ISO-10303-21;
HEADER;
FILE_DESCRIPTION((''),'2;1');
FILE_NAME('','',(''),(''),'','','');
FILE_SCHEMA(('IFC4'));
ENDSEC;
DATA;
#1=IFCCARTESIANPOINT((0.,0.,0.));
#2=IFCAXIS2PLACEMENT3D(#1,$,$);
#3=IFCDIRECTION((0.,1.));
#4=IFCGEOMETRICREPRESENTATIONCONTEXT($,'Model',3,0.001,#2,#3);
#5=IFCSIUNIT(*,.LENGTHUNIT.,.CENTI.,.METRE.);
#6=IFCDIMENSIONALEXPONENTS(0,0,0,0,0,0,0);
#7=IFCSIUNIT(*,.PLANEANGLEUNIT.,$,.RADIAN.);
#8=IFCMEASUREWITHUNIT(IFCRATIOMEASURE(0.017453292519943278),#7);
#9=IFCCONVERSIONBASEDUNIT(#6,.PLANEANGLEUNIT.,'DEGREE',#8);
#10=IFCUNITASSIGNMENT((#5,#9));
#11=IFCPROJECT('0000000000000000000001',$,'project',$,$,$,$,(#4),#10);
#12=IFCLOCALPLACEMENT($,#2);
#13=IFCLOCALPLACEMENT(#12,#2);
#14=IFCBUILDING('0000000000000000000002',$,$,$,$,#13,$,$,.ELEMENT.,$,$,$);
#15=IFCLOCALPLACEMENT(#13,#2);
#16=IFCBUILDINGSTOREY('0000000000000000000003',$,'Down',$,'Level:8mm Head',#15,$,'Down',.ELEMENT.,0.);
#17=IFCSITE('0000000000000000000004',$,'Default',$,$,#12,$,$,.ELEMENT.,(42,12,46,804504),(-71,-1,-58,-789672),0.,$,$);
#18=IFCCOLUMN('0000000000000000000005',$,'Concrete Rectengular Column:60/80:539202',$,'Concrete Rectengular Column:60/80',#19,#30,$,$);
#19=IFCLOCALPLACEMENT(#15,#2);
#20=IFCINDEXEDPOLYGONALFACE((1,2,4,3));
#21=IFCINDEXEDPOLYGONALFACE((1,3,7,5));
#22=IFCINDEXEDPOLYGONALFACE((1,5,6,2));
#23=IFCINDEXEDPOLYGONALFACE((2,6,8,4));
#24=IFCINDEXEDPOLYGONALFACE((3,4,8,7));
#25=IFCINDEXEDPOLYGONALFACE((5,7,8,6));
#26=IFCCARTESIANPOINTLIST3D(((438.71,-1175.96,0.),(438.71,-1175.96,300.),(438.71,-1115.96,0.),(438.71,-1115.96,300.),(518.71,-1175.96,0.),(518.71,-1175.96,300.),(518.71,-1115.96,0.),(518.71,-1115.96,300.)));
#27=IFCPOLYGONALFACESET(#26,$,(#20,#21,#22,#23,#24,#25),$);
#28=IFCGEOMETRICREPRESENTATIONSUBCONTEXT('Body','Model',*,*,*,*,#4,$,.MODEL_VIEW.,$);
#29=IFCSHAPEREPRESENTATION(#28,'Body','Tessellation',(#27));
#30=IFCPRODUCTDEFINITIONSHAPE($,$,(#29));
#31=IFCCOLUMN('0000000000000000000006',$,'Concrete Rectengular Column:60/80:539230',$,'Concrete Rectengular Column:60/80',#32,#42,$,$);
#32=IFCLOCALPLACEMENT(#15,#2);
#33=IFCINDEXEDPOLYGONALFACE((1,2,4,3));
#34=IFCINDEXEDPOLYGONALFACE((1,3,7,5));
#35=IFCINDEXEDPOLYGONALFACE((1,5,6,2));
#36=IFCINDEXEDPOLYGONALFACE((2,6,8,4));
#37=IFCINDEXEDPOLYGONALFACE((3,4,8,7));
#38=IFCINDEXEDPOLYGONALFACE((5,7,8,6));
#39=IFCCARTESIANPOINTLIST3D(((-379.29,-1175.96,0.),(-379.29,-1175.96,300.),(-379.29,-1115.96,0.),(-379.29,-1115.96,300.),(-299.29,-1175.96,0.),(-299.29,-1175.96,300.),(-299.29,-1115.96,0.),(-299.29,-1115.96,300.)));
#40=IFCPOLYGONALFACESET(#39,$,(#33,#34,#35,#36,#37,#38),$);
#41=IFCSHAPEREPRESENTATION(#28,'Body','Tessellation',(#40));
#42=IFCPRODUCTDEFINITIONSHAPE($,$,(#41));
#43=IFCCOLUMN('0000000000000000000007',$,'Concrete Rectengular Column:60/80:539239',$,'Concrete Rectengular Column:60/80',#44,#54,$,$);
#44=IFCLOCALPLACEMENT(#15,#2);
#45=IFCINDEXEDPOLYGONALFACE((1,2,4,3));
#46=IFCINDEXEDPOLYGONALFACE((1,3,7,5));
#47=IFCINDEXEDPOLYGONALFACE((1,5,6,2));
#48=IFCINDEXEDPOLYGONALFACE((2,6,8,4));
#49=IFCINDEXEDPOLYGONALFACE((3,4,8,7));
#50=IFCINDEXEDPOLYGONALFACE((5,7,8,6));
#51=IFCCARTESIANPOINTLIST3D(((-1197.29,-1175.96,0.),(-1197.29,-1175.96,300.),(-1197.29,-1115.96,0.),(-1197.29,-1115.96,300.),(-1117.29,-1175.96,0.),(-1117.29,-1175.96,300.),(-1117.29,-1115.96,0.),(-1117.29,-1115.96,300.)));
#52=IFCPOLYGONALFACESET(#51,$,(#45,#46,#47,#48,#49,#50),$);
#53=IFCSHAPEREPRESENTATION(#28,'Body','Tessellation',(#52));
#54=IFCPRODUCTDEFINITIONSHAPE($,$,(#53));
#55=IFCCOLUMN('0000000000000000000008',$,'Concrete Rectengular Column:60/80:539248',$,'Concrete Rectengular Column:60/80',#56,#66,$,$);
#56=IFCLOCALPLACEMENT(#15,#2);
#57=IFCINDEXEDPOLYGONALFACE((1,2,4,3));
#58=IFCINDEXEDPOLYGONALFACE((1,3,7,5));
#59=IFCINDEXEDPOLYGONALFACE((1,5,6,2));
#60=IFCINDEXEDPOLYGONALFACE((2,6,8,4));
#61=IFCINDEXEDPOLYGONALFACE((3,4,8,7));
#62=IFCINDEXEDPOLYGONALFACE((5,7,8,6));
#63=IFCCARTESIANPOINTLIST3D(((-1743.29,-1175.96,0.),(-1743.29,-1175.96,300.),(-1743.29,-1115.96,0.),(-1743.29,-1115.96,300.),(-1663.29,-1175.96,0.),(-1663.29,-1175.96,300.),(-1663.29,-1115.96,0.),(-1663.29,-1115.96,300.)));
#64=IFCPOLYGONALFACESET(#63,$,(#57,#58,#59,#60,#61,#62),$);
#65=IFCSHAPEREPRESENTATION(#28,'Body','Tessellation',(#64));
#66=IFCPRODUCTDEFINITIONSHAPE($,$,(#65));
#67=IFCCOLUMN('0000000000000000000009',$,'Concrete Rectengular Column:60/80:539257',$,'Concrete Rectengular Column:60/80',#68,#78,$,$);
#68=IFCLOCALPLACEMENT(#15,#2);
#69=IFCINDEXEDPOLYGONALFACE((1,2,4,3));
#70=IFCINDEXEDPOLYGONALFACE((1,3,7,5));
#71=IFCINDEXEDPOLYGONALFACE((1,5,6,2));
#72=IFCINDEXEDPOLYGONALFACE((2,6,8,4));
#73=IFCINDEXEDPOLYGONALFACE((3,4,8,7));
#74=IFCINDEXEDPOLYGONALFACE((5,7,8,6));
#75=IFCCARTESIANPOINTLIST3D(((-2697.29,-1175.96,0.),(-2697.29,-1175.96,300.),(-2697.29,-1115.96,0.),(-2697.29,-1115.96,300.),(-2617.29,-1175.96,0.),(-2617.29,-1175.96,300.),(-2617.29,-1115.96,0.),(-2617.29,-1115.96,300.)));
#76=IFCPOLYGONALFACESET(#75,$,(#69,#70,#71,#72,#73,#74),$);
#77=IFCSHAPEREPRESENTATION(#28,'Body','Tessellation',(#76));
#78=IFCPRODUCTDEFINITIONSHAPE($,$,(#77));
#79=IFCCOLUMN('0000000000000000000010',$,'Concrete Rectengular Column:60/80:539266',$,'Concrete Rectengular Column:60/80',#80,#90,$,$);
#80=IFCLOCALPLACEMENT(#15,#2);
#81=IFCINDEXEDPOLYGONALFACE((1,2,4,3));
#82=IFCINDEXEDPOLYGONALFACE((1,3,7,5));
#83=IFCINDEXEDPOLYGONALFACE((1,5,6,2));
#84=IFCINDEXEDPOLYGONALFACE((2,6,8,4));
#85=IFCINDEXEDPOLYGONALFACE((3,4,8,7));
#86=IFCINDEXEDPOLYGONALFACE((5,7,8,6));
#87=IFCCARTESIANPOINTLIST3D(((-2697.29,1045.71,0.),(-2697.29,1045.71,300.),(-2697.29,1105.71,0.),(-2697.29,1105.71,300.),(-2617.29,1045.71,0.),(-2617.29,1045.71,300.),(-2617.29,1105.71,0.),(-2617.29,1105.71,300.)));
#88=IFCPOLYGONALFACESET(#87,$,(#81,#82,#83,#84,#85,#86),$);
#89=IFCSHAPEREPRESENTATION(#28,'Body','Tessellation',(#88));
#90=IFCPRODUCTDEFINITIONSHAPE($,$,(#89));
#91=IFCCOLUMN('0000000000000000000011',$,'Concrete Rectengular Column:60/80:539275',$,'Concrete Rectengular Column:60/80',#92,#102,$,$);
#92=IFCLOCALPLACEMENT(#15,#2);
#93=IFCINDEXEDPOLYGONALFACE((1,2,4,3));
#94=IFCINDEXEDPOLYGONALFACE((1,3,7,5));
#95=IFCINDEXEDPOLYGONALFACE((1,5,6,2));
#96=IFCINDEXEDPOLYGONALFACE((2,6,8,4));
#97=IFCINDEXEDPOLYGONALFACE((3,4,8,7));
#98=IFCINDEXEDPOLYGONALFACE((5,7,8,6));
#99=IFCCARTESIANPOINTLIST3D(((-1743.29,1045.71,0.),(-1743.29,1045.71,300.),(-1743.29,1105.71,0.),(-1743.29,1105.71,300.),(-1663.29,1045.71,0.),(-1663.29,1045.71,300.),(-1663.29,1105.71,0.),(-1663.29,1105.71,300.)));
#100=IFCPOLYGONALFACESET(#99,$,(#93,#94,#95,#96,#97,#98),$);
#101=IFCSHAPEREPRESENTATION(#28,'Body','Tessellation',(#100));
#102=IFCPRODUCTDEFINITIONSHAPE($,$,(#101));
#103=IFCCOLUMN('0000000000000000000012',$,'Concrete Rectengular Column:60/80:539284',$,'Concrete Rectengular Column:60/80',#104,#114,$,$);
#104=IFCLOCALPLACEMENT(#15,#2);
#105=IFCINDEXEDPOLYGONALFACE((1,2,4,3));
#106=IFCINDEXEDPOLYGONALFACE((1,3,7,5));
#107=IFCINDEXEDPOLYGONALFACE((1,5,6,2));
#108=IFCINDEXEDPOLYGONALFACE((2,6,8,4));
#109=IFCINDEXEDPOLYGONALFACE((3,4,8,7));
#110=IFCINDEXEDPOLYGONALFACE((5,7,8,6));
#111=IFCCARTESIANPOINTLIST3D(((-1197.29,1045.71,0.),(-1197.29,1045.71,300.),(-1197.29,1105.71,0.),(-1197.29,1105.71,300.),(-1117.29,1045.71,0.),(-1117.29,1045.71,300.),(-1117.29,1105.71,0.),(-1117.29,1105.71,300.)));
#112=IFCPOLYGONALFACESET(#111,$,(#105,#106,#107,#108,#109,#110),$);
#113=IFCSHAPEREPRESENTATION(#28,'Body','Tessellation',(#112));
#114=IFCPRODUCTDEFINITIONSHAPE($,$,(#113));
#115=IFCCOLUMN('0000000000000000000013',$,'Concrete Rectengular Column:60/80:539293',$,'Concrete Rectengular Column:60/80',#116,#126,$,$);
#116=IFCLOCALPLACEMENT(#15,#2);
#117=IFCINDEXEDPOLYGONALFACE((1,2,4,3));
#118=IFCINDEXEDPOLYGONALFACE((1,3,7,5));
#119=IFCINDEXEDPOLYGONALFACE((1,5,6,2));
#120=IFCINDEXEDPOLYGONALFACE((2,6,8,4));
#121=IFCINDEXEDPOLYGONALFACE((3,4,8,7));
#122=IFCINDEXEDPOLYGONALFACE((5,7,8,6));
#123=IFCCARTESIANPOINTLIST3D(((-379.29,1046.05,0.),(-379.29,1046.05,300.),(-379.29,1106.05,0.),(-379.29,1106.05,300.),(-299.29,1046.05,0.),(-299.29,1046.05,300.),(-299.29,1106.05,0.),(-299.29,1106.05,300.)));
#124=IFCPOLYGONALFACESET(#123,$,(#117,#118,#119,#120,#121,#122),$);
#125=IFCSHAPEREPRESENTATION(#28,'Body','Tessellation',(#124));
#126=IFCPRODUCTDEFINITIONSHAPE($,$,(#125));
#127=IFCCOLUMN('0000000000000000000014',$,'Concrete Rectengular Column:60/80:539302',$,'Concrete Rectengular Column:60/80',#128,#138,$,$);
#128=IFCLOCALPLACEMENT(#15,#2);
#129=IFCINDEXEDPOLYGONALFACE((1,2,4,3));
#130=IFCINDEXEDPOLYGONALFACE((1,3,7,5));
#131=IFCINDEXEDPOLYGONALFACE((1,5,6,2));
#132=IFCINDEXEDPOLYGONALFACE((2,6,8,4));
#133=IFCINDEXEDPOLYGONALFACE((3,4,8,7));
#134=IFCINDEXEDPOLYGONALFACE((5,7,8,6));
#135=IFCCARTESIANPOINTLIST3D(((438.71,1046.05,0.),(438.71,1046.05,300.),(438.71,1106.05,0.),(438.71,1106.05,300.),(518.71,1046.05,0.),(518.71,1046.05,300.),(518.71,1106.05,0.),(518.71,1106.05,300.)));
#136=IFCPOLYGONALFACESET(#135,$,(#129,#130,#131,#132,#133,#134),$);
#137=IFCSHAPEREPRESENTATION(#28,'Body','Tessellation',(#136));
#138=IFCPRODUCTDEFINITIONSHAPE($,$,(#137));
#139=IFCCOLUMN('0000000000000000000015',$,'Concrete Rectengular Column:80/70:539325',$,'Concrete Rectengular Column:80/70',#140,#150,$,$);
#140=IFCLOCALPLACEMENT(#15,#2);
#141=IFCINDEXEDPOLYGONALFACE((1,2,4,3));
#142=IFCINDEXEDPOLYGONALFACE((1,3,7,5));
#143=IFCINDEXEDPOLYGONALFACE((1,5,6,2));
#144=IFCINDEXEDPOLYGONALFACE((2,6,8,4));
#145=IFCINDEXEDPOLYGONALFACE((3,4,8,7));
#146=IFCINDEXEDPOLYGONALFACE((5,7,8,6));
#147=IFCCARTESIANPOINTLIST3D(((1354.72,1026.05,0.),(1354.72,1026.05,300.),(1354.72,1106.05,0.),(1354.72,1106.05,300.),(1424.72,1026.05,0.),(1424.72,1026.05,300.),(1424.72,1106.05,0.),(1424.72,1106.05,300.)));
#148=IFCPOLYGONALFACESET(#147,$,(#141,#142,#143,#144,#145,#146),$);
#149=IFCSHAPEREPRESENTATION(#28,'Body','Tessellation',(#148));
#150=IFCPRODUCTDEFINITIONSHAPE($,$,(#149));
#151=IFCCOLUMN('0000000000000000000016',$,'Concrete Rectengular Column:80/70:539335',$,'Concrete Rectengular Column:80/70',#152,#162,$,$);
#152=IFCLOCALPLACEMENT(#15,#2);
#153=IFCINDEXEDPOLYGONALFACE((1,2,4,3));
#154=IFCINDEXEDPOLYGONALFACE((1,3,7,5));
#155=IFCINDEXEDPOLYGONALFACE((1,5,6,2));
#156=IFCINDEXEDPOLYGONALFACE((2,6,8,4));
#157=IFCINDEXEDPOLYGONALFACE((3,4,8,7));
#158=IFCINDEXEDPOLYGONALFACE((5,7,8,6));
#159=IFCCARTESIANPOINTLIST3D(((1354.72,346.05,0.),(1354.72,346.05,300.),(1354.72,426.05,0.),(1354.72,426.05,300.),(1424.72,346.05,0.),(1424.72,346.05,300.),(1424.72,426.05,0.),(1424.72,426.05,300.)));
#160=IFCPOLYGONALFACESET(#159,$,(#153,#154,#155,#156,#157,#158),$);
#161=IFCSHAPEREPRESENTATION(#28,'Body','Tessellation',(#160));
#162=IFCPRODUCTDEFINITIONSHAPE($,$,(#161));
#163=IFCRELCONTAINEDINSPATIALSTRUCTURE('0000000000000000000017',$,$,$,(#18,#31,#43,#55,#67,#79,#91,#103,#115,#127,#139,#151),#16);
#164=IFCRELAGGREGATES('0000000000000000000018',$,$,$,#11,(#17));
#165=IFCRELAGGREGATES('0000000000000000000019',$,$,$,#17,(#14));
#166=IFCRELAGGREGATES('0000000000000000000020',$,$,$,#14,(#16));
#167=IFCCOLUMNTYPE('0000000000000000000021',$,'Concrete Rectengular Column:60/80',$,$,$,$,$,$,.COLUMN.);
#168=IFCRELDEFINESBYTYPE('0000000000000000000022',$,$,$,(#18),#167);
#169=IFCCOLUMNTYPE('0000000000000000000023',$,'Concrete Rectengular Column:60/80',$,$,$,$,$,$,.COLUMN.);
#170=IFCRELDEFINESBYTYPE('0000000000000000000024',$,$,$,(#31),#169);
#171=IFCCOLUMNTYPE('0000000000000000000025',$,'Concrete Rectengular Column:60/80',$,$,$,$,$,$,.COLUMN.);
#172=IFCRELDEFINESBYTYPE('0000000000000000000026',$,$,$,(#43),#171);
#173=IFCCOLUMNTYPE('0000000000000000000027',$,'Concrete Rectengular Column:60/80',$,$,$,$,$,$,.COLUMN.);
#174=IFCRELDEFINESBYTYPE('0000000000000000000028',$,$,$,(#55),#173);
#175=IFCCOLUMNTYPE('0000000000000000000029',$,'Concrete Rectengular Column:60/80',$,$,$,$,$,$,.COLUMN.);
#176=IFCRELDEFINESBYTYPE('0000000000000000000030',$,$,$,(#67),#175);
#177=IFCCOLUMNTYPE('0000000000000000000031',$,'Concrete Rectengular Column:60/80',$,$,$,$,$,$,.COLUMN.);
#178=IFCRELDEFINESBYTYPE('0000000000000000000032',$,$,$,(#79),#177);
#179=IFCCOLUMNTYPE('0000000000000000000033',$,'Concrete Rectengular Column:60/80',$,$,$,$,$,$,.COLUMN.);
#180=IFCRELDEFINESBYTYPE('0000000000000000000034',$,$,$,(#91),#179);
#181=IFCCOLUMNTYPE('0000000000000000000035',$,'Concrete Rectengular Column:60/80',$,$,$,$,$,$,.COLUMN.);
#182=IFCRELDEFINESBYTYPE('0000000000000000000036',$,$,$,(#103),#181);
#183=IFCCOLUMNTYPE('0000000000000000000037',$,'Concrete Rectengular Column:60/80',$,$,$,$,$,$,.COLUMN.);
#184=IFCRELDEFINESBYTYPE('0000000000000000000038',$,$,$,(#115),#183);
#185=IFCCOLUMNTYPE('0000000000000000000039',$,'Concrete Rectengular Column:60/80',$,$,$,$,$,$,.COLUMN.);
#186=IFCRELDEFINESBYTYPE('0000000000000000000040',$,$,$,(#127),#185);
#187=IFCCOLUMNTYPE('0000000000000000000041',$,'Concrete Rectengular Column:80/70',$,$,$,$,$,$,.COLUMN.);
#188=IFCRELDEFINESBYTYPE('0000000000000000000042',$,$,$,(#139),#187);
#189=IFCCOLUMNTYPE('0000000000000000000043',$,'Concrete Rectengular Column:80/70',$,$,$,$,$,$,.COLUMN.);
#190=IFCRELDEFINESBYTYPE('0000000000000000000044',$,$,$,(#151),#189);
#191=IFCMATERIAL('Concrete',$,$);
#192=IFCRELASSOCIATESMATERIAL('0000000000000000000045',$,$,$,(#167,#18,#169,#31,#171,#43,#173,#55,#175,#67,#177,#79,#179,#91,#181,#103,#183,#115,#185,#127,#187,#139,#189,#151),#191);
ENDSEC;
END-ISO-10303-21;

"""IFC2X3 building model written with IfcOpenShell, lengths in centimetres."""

from ifc_helpers import new_model, entity, si_unit, converted_unit, direction, frame, frame_2d, origin, origin_2d_with_axis, place, context, subcontext, project, spatial, rectangle, extrude, source, transform, mapped, material, type_object, type_shapes, element, save


model = new_model("IFC2X3")

# Units and contexts
model_context = context("Model", 3, precision=0.001, world=origin(), true_north=direction((0.0, 1.0)))
body_context = subcontext(model_context, "Body", "Model", "MODEL_VIEW")
ifc_project = project(units=[si_unit("LENGTHUNIT", "METRE", prefix="CENTI"), converted_unit("PLANEANGLEUNIT", "DEGREE", entity("IfcRatioMeasure", 0.017453292519943278), si_unit("PLANEANGLEUNIT", "RADIAN"), dimensions=[0, 0, 0, 0, 0, 0, 0])], contexts=[model_context])

# Site, building, storey
site_placement = place(None, origin())
site = spatial("IfcSite", under=ifc_project, at=site_placement, Name="Default", CompositionType="ELEMENT", RefLatitude=(42, 12, 46, 804504), RefLongitude=(-71, -1, -58, -789672), RefElevation=0.0)
building_placement = place(site_placement, origin())
building = spatial("IfcBuilding", under=site, at=building_placement, CompositionType="ELEMENT")
storey_placement = place(building_placement, origin())
storey = spatial("IfcBuildingStorey", under=building, at=storey_placement, Name="Down", ObjectType="Level:8mm Head", LongName="Down", CompositionType="ELEMENT", Elevation=0.0)

# Columns
ifc_material = material(Name="Concrete")
column_type_1 = type_object("IfcColumnType", Name="Concrete Rectengular Column:60/80", PredefinedType="COLUMN", material=ifc_material)
shared_shape_1 = source(origin(), body_context, "Body", "SweptSolid", [
    extrude(rectangle(XDim=60.0, YDim=80.0, at=frame_2d((0.0, 0.0), x_axis=(1.0, 0.0))), frame((478.71, -1145.96, 0.0), z_axis=(0.0, 0.0, 1.0), x_axis=(0.0, -1.0, 0.0)), (0.0, 0.0, 1.0), 300.0),
])
type_shapes(column_type_1, [shared_shape_1])
column_1_placement = place(storey_placement, origin())
element("IfcColumn", 1, at=column_1_placement, inside=storey, type_object=column_type_1, material=ifc_material, Name="Concrete Rectengular Column:60/80:539202", ObjectType="Concrete Rectengular Column:60/80", context=body_context, shape_type="MappedRepresentation", body=[
    mapped(shared_shape_1, transform((0.0, 0.0, 0.0), scale=1.0)),
])
column_type_2 = type_object("IfcColumnType", Name="Concrete Rectengular Column:60/80", PredefinedType="COLUMN", material=ifc_material)
shared_shape_2 = source(origin(), body_context, "Body", "SweptSolid", [
    extrude(rectangle(XDim=60.0, YDim=80.0, at=frame_2d((0.0, 0.0), x_axis=(1.0, 0.0))), frame((-339.29, -1145.96, 0.0), z_axis=(0.0, 0.0, 1.0), x_axis=(0.0, -1.0, 0.0)), (0.0, 0.0, 1.0), 300.0),
])
type_shapes(column_type_2, [shared_shape_2])
column_2_placement = place(storey_placement, origin())
element("IfcColumn", 2, at=column_2_placement, inside=storey, type_object=column_type_2, material=ifc_material, Name="Concrete Rectengular Column:60/80:539230", ObjectType="Concrete Rectengular Column:60/80", context=body_context, shape_type="MappedRepresentation", body=[
    mapped(shared_shape_2, transform((0.0, 0.0, 0.0), scale=1.0)),
])
column_type_3 = type_object("IfcColumnType", Name="Concrete Rectengular Column:60/80", PredefinedType="COLUMN", material=ifc_material)
shared_shape_3 = source(origin(), body_context, "Body", "SweptSolid", [
    extrude(rectangle(XDim=60.0, YDim=80.0, at=frame_2d((0.0, 0.0), x_axis=(1.0, 0.0))), frame((-1157.29, -1145.96, 0.0), z_axis=(0.0, 0.0, 1.0), x_axis=(0.0, -1.0, 0.0)), (0.0, 0.0, 1.0), 300.0),
])
type_shapes(column_type_3, [shared_shape_3])
column_3_placement = place(storey_placement, origin())
element("IfcColumn", 3, at=column_3_placement, inside=storey, type_object=column_type_3, material=ifc_material, Name="Concrete Rectengular Column:60/80:539239", ObjectType="Concrete Rectengular Column:60/80", context=body_context, shape_type="MappedRepresentation", body=[
    mapped(shared_shape_3, transform((0.0, 0.0, 0.0), scale=1.0)),
])
column_type_4 = type_object("IfcColumnType", Name="Concrete Rectengular Column:60/80", PredefinedType="COLUMN", material=ifc_material)
shared_shape_4 = source(origin(), body_context, "Body", "SweptSolid", [
    extrude(rectangle(XDim=60.0, YDim=80.0, at=frame_2d((0.0, 0.0), x_axis=(1.0, 0.0))), frame((-1703.29, -1145.96, 0.0), z_axis=(0.0, 0.0, 1.0), x_axis=(0.0, -1.0, 0.0)), (0.0, 0.0, 1.0), 300.0),
])
type_shapes(column_type_4, [shared_shape_4])
column_4_placement = place(storey_placement, origin())
element("IfcColumn", 4, at=column_4_placement, inside=storey, type_object=column_type_4, material=ifc_material, Name="Concrete Rectengular Column:60/80:539248", ObjectType="Concrete Rectengular Column:60/80", context=body_context, shape_type="MappedRepresentation", body=[
    mapped(shared_shape_4, transform((0.0, 0.0, 0.0), scale=1.0)),
])
column_type_5 = type_object("IfcColumnType", Name="Concrete Rectengular Column:60/80", PredefinedType="COLUMN", material=ifc_material)
shared_shape_5 = source(origin(), body_context, "Body", "SweptSolid", [
    extrude(rectangle(XDim=60.0, YDim=80.0, at=frame_2d((0.0, 0.0), x_axis=(1.0, 0.0))), frame((-2657.29, -1145.96, 0.0), z_axis=(0.0, 0.0, 1.0), x_axis=(0.0, -1.0, 0.0)), (0.0, 0.0, 1.0), 300.0),
])
type_shapes(column_type_5, [shared_shape_5])
column_5_placement = place(storey_placement, origin())
element("IfcColumn", 5, at=column_5_placement, inside=storey, type_object=column_type_5, material=ifc_material, Name="Concrete Rectengular Column:60/80:539257", ObjectType="Concrete Rectengular Column:60/80", context=body_context, shape_type="MappedRepresentation", body=[
    mapped(shared_shape_5, transform((0.0, 0.0, 0.0), scale=1.0)),
])
column_type_6 = type_object("IfcColumnType", Name="Concrete Rectengular Column:60/80", PredefinedType="COLUMN", material=ifc_material)
shared_shape_6 = source(origin(), body_context, "Body", "SweptSolid", [
    extrude(rectangle(XDim=60.0, YDim=80.0, at=frame_2d((0.0, 0.0), x_axis=(1.0, 0.0))), frame((-2657.29, 1075.71, 0.0), z_axis=(0.0, 0.0, 1.0), x_axis=(0.0, -1.0, 0.0)), (0.0, 0.0, 1.0), 300.0),
])
type_shapes(column_type_6, [shared_shape_6])
column_6_placement = place(storey_placement, origin())
element("IfcColumn", 6, at=column_6_placement, inside=storey, type_object=column_type_6, material=ifc_material, Name="Concrete Rectengular Column:60/80:539266", ObjectType="Concrete Rectengular Column:60/80", context=body_context, shape_type="MappedRepresentation", body=[
    mapped(shared_shape_6, transform((0.0, 0.0, 0.0), scale=1.0)),
])
column_type_7 = type_object("IfcColumnType", Name="Concrete Rectengular Column:60/80", PredefinedType="COLUMN", material=ifc_material)
shared_shape_7 = source(origin(), body_context, "Body", "SweptSolid", [
    extrude(rectangle(XDim=60.0, YDim=80.0, at=frame_2d((0.0, 0.0), x_axis=(1.0, 0.0))), frame((-1703.29, 1075.71, 0.0), z_axis=(0.0, 0.0, 1.0), x_axis=(0.0, -1.0, 0.0)), (0.0, 0.0, 1.0), 300.0),
])
type_shapes(column_type_7, [shared_shape_7])
column_7_placement = place(storey_placement, origin())
element("IfcColumn", 7, at=column_7_placement, inside=storey, type_object=column_type_7, material=ifc_material, Name="Concrete Rectengular Column:60/80:539275", ObjectType="Concrete Rectengular Column:60/80", context=body_context, shape_type="MappedRepresentation", body=[
    mapped(shared_shape_7, transform((0.0, 0.0, 0.0), scale=1.0)),
])
column_type_8 = type_object("IfcColumnType", Name="Concrete Rectengular Column:60/80", PredefinedType="COLUMN", material=ifc_material)
shared_shape_8 = source(origin(), body_context, "Body", "SweptSolid", [
    extrude(rectangle(XDim=60.0, YDim=80.0, at=frame_2d((0.0, 0.0), x_axis=(1.0, 0.0))), frame((-1157.29, 1075.71, 0.0), z_axis=(0.0, 0.0, 1.0), x_axis=(0.0, -1.0, 0.0)), (0.0, 0.0, 1.0), 300.0),
])
type_shapes(column_type_8, [shared_shape_8])
column_8_placement = place(storey_placement, origin())
element("IfcColumn", 8, at=column_8_placement, inside=storey, type_object=column_type_8, material=ifc_material, Name="Concrete Rectengular Column:60/80:539284", ObjectType="Concrete Rectengular Column:60/80", context=body_context, shape_type="MappedRepresentation", body=[
    mapped(shared_shape_8, transform((0.0, 0.0, 0.0), scale=1.0)),
])
column_type_9 = type_object("IfcColumnType", Name="Concrete Rectengular Column:60/80", PredefinedType="COLUMN", material=ifc_material)
shared_shape_9 = source(origin(), body_context, "Body", "SweptSolid", [
    extrude(rectangle(XDim=60.0, YDim=80.0, at=frame_2d((0.0, 0.0), x_axis=(1.0, 0.0))), frame((-339.29, 1076.05, 0.0), z_axis=(0.0, 0.0, 1.0), x_axis=(0.0, -1.0, 0.0)), (0.0, 0.0, 1.0), 300.0),
])
type_shapes(column_type_9, [shared_shape_9])
column_9_placement = place(storey_placement, origin())
element("IfcColumn", 9, at=column_9_placement, inside=storey, type_object=column_type_9, material=ifc_material, Name="Concrete Rectengular Column:60/80:539293", ObjectType="Concrete Rectengular Column:60/80", context=body_context, shape_type="MappedRepresentation", body=[
    mapped(shared_shape_9, transform((0.0, 0.0, 0.0), scale=1.0)),
])
column_type_10 = type_object("IfcColumnType", Name="Concrete Rectengular Column:60/80", PredefinedType="COLUMN", material=ifc_material)
shared_shape_10 = source(origin(), body_context, "Body", "SweptSolid", [
    extrude(rectangle(XDim=60.0, YDim=80.0, at=frame_2d((0.0, 0.0), x_axis=(1.0, 0.0))), frame((478.71, 1076.05, 0.0), z_axis=(0.0, 0.0, 1.0), x_axis=(0.0, -1.0, 0.0)), (0.0, 0.0, 1.0), 300.0),
])
type_shapes(column_type_10, [shared_shape_10])
column_10_placement = place(storey_placement, origin())
element("IfcColumn", 10, at=column_10_placement, inside=storey, type_object=column_type_10, material=ifc_material, Name="Concrete Rectengular Column:60/80:539302", ObjectType="Concrete Rectengular Column:60/80", context=body_context, shape_type="MappedRepresentation", body=[
    mapped(shared_shape_10, transform((0.0, 0.0, 0.0), scale=1.0)),
])
column_type_11 = type_object("IfcColumnType", Name="Concrete Rectengular Column:80/70", PredefinedType="COLUMN", material=ifc_material)
shared_shape_11 = source(origin(), body_context, "Body", "SweptSolid", [
    extrude(rectangle(XDim=80.0, YDim=70.0, at=origin_2d_with_axis()), frame((1389.72, 1066.05, 0.0), z_axis=(0.0, 0.0, 1.0), x_axis=(0.0, -1.0, 0.0)), (0.0, 0.0, 1.0), 300.0),
])
type_shapes(column_type_11, [shared_shape_11])
column_11_placement = place(storey_placement, origin())
element("IfcColumn", 11, at=column_11_placement, inside=storey, type_object=column_type_11, material=ifc_material, Name="Concrete Rectengular Column:80/70:539325", ObjectType="Concrete Rectengular Column:80/70", context=body_context, shape_type="MappedRepresentation", body=[
    mapped(shared_shape_11, transform((0.0, 0.0, 0.0), scale=1.0)),
])
column_type_12 = type_object("IfcColumnType", Name="Concrete Rectengular Column:80/70", PredefinedType="COLUMN", material=ifc_material)
shared_shape_12 = source(origin(), body_context, "Body", "SweptSolid", [
    extrude(rectangle(XDim=80.0, YDim=70.0, at=frame_2d((0.0, 0.0), x_axis=(1.0, 0.0))), frame((1389.72, 386.05, 0.0), z_axis=(0.0, 0.0, 1.0), x_axis=(0.0, -1.0, 0.0)), (0.0, 0.0, 1.0), 300.0),
])
type_shapes(column_type_12, [shared_shape_12])
column_12_placement = place(storey_placement, origin())
element("IfcColumn", 12, at=column_12_placement, inside=storey, type_object=column_type_12, material=ifc_material, Name="Concrete Rectengular Column:80/70:539335", ObjectType="Concrete Rectengular Column:80/70", context=body_context, shape_type="MappedRepresentation", body=[
    mapped(shared_shape_12, transform((0.0, 0.0, 0.0), scale=1.0)),
])

save(model, "model.ifc")
